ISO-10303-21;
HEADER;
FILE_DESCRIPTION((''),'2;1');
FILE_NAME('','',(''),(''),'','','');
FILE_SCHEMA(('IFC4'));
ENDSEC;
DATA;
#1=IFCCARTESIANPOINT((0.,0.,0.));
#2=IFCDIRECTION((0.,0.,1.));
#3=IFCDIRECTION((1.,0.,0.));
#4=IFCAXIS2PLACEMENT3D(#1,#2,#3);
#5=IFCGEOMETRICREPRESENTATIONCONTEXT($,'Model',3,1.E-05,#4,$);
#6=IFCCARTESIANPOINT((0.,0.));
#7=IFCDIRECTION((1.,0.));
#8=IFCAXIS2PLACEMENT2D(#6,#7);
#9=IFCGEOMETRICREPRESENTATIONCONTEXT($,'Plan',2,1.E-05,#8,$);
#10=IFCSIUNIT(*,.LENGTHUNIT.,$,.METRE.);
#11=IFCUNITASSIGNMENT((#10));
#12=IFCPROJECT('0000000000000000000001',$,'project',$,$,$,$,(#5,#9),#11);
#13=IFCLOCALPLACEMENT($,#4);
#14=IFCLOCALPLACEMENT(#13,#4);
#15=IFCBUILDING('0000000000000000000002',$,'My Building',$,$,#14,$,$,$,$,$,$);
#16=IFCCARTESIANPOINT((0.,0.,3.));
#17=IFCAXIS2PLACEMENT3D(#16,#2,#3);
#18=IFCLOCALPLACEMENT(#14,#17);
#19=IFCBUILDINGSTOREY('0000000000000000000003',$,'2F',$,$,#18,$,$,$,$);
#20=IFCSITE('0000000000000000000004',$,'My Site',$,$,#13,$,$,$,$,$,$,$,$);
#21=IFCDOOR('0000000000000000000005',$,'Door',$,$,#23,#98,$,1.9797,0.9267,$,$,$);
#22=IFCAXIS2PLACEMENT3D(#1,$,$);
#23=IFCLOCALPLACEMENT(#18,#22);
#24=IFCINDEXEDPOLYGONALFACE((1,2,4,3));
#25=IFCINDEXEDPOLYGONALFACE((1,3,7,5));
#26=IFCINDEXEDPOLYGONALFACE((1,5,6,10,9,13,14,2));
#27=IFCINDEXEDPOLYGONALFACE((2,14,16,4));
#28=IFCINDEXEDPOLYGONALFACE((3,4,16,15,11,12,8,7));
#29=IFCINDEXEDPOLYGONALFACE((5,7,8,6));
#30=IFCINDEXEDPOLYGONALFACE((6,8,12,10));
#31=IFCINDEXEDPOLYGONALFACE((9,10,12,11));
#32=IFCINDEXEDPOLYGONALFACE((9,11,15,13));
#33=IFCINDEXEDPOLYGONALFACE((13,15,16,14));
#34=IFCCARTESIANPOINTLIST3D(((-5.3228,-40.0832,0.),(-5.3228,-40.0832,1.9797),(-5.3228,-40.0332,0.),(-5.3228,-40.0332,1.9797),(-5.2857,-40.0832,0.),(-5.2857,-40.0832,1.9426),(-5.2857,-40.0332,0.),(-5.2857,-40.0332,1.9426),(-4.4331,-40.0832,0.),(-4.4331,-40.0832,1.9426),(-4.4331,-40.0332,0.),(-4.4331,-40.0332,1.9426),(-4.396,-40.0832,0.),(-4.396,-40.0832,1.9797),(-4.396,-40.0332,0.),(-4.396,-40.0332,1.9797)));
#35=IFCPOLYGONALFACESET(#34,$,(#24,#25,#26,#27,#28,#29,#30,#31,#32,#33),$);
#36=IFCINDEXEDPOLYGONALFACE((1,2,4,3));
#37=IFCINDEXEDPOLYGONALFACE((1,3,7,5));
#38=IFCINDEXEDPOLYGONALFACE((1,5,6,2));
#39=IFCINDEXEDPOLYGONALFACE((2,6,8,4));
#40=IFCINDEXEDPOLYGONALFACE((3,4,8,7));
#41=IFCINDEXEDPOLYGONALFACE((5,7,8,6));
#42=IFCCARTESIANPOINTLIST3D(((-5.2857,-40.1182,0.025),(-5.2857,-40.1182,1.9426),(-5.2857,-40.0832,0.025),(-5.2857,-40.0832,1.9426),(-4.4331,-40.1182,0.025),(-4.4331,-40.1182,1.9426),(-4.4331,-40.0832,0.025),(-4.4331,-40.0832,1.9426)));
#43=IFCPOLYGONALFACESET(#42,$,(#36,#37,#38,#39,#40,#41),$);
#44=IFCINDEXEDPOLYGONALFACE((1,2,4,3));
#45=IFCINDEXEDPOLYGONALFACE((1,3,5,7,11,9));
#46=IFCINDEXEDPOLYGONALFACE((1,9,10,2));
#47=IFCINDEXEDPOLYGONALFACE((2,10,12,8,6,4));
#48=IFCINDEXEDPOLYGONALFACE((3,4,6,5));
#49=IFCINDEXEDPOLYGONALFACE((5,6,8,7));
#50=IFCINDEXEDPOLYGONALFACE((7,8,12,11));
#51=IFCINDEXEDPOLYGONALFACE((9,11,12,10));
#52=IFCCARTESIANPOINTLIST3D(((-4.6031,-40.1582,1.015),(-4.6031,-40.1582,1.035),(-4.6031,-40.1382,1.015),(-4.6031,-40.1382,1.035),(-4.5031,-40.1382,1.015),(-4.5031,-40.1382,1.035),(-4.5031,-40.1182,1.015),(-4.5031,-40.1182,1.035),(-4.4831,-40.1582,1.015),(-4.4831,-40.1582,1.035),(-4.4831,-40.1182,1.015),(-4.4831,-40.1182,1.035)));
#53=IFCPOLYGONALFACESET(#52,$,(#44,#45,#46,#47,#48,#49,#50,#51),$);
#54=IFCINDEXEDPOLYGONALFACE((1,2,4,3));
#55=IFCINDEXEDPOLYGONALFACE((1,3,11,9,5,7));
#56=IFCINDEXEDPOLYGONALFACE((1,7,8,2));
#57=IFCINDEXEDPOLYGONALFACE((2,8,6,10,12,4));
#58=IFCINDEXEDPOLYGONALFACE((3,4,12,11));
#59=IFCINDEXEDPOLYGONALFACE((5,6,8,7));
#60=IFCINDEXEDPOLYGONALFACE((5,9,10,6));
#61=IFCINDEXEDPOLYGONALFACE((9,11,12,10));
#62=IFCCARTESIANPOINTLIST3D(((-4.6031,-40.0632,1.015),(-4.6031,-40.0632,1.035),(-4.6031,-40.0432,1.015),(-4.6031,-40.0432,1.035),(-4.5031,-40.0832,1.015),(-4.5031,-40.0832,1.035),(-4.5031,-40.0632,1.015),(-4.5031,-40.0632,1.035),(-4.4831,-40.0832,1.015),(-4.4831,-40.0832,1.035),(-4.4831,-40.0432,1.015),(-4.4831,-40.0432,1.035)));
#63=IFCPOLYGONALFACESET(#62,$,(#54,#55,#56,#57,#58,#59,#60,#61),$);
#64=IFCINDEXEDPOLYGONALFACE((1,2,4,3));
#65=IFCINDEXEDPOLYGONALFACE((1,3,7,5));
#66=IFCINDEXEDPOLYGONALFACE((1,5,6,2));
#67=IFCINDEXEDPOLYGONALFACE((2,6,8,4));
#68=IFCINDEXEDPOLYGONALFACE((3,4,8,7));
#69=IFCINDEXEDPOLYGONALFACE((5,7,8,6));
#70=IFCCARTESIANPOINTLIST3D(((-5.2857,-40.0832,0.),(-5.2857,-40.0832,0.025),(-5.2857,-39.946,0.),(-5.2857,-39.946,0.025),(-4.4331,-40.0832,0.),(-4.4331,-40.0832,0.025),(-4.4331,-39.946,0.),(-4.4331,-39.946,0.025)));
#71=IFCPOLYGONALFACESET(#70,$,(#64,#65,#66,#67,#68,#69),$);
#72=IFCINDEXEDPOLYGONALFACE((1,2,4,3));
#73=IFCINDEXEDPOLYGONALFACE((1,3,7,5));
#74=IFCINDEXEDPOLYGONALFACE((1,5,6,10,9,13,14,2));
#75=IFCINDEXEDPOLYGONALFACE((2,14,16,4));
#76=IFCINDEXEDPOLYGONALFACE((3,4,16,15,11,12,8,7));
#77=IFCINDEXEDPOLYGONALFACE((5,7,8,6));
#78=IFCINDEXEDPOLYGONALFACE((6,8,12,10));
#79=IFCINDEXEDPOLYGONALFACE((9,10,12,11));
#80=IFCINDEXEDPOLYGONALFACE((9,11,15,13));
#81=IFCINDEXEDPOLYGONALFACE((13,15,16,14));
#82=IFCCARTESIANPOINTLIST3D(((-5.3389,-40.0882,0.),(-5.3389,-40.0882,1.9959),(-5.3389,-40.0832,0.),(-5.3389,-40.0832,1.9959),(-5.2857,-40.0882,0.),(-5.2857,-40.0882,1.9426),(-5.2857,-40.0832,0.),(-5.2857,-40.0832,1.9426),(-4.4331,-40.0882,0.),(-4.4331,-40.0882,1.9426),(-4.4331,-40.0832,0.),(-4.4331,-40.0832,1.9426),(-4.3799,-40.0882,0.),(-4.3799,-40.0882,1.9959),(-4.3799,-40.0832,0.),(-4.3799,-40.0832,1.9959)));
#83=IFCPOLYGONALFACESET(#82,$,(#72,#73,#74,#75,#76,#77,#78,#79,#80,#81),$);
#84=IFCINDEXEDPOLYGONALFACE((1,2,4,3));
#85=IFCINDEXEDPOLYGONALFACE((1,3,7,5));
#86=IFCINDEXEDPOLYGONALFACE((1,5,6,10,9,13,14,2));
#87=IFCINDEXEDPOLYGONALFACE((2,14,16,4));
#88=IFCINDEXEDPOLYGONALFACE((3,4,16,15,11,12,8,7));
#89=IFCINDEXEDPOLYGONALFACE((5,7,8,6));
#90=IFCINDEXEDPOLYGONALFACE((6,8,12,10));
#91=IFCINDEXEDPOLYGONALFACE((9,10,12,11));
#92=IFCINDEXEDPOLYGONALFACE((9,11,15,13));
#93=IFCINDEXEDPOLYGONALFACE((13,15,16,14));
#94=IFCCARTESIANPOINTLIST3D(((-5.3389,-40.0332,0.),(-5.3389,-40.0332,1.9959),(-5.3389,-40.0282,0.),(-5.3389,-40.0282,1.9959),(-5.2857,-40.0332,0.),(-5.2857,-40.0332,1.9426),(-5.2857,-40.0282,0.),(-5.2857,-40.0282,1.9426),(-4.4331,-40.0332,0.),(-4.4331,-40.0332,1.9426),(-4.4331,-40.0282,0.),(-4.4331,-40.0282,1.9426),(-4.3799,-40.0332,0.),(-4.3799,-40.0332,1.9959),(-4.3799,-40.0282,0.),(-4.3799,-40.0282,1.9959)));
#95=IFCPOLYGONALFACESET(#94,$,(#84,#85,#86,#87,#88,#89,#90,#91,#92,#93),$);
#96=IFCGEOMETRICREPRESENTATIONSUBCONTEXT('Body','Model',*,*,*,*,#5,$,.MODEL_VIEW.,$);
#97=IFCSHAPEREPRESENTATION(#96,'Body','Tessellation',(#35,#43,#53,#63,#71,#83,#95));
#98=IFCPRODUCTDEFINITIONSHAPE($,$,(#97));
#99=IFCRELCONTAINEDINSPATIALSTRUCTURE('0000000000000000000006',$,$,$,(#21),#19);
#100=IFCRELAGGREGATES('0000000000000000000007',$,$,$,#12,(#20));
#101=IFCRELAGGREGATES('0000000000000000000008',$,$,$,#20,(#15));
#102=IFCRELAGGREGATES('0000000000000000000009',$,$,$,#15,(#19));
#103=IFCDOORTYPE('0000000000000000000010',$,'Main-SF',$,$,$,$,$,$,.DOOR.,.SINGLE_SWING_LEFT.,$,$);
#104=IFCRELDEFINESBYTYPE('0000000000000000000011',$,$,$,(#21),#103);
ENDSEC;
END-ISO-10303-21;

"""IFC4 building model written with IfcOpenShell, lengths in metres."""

from ifc_helpers import new_model, entity, si_unit, frame, origin_with_axes, origin_2d_with_axis, place, context, subcontext, project, spatial, line, indexed_curve, outline, extrude, shape, source, transform, mapped, type_object, type_shapes, element, save


model = new_model("IFC4")

# Units and contexts
model_context = context("Model", 3, precision=1e-05, world=origin_with_axes())
plan_context = context("Plan", 2, precision=1e-05, world=origin_2d_with_axis())
body_context_1 = subcontext(model_context, "Body", "Model", "MODEL_VIEW")
body_context_2 = subcontext(plan_context, "Body", "Plan", "PLAN_VIEW")
ifc_project = project(units=[si_unit("LENGTHUNIT", "METRE")], contexts=[model_context, plan_context])

# Site, building, storey
site_placement = place(None, origin_with_axes())
site = spatial("IfcSite", under=ifc_project, at=site_placement, Name="My Site")
building_placement = place(site_placement, origin_with_axes())
building = spatial("IfcBuilding", under=site, at=building_placement, Name="My Building")
storey_placement = place(building_placement, frame((0.0, 0.0, 3.0), z_axis=(0.0, 0.0, 1.0), x_axis=(1.0, 0.0, 0.0)))
storey = spatial("IfcBuildingStorey", under=building, at=storey_placement, Name="2F")

# Door
door_type_1 = type_object("IfcDoorType", Name="Main-SF", OperationType="SINGLE_SWING_LEFT", PredefinedType="DOOR")
shared_shape_1 = source(origin_with_axes(), body_context_1, "Body", "SweptSolid", [
    extrude(outline(indexed_curve([(0.0, 0.0), (0.0, 1.9797), (0.9267, 1.9797), (0.9267, 0.0), (0.8896, 0.0), (0.8896, 1.9426), (0.0371, 1.9426), (0.0371, 0.0)], segments=[line(1, 2, 3, 4, 5, 6, 7, 8, 1)])), frame((0.0, 0.0, 0.0), z_axis=(0.0, -1.0, 0.0), x_axis=(1.0, 0.0, 0.0)), (0.0, 0.0, -1.0), 0.05),
    extrude(outline(indexed_curve([(0.0, 0.0), (0.8526, 0.0), (0.8526, 0.035), (0.0, 0.035)], segments=[line(1, 2, 3, 4, 1)])), frame((0.0371, -0.035, 0.025), z_axis=(0.0, 0.0, 1.0), x_axis=(1.0, 0.0, 0.0)), (0.0, 0.0, 1.0), 1.9176),
    extrude(outline(indexed_curve([(0.0, 0.0), (0.0, -0.04), (-0.12, -0.04), (-0.12, -0.02), (-0.02, -0.02), (-0.02, 0.0)], segments=[line(1, 2, 3, 4, 5, 6, 1)])), frame((0.8396, -0.035, 1.015), z_axis=(0.0, 0.0, 1.0), x_axis=(1.0, 0.0, 0.0)), (0.0, 0.0, 1.0), 0.02),
    extrude(outline(indexed_curve([(0.0, 0.0), (0.0, 0.04), (-0.12, 0.04), (-0.12, 0.02), (-0.02, 0.02), (-0.02, 0.0)], segments=[line(1, 2, 3, 4, 5, 6, 1)])), frame((0.8396, 0.0, 1.015), z_axis=(0.0, 0.0, 1.0), x_axis=(1.0, 0.0, 0.0)), (0.0, 0.0, 1.0), 0.02),
    extrude(outline(indexed_curve([(0.0, 0.0), (0.8526, 0.0), (0.8526, 0.1372), (0.0, 0.1372)], segments=[line(1, 2, 3, 4, 1)])), frame((0.0371, 0.0, 0.0), z_axis=(0.0, 0.0, 1.0), x_axis=(1.0, 0.0, 0.0)), (0.0, 0.0, 1.0), 0.025),
    extrude(outline(indexed_curve([(0.0, 0.0), (0.0, 1.9959), (0.959, 1.9959), (0.959, 0.0), (0.9058, 0.0), (0.9058, 1.9426), (0.0532, 1.9426), (0.0532, 0.0)], segments=[line(1, 2, 3, 4, 5, 6, 7, 8, 1)])), frame((-0.0162, -0.005, 0.0), z_axis=(0.0, -1.0, 0.0), x_axis=(1.0, 0.0, 0.0)), (0.0, 0.0, -1.0), 0.005),
    extrude(outline(indexed_curve([(0.0, 0.0), (0.0, 1.9959), (0.959, 1.9959), (0.959, 0.0), (0.9058, 0.0), (0.9058, 1.9426), (0.0532, 1.9426), (0.0532, 0.0)], segments=[line(1, 2, 3, 4, 5, 6, 7, 8, 1)])), frame((-0.0162, 0.05, 0.0), z_axis=(0.0, -1.0, 0.0), x_axis=(1.0, 0.0, 0.0)), (0.0, 0.0, -1.0), 0.005),
])
shared_shape_2 = source(origin_with_axes(), body_context_2, "Body", "Curve2D", [
    entity("IfcIndexedPolyCurve", entity("IfcCartesianPointList2D", [[0.0, 0.0], [0.0371, 0.0], [0.0371, 0.05], [0.0, 0.05]]), [entity("IfcLineIndex", [1, 2, 3, 4, 1])]),
    entity("IfcIndexedPolyCurve", entity("IfcCartesianPointList2D", [[0.9267, 0.0], [0.8896, 0.0], [0.8896, 0.05], [0.9267, 0.05]]), [entity("IfcLineIndex", [1, 2, 3, 4, 1])]),
    entity("IfcIndexedPolyCurve", entity("IfcCartesianPointList2D", [[-0.3892, -0.035], [0.4634, -0.035], [0.4634, 0.0], [-0.3892, 0.0]]), [entity("IfcLineIndex", [1, 2, 3, 4, 1])]),
])
type_shapes(door_type_1, [shared_shape_1, shared_shape_2])
door_1_placement = place(storey_placement, frame((-5.3228, -40.0832, 0.0), z_axis=(0.0, 0.0, 1.0), x_axis=(1.0, 0.0, 0.0)))
element("IfcDoor", 1, at=door_1_placement, inside=storey, type_object=door_type_1, Name="Door", OverallHeight=1.9797, OverallWidth=0.9267, shapes=[
    shape(body_context_1, "Body", "MappedRepresentation", [mapped(shared_shape_1, transform((0.0, 0.0, 0.0), x_axis=(1.0, 0.0, 0.0), y_axis=(0.0, 1.0, 0.0), z_axis=(0.0, 0.0, 1.0), scale=1.0))]),
    shape(body_context_2, "Body", "MappedRepresentation", [mapped(shared_shape_2, transform((0.0, 0.0, 0.0), x_axis=(1.0, 0.0, 0.0), y_axis=(0.0, 1.0, 0.0), z_axis=(0.0, 0.0, 1.0), scale=1.0))]),
])

save(model, "model.ifc")
